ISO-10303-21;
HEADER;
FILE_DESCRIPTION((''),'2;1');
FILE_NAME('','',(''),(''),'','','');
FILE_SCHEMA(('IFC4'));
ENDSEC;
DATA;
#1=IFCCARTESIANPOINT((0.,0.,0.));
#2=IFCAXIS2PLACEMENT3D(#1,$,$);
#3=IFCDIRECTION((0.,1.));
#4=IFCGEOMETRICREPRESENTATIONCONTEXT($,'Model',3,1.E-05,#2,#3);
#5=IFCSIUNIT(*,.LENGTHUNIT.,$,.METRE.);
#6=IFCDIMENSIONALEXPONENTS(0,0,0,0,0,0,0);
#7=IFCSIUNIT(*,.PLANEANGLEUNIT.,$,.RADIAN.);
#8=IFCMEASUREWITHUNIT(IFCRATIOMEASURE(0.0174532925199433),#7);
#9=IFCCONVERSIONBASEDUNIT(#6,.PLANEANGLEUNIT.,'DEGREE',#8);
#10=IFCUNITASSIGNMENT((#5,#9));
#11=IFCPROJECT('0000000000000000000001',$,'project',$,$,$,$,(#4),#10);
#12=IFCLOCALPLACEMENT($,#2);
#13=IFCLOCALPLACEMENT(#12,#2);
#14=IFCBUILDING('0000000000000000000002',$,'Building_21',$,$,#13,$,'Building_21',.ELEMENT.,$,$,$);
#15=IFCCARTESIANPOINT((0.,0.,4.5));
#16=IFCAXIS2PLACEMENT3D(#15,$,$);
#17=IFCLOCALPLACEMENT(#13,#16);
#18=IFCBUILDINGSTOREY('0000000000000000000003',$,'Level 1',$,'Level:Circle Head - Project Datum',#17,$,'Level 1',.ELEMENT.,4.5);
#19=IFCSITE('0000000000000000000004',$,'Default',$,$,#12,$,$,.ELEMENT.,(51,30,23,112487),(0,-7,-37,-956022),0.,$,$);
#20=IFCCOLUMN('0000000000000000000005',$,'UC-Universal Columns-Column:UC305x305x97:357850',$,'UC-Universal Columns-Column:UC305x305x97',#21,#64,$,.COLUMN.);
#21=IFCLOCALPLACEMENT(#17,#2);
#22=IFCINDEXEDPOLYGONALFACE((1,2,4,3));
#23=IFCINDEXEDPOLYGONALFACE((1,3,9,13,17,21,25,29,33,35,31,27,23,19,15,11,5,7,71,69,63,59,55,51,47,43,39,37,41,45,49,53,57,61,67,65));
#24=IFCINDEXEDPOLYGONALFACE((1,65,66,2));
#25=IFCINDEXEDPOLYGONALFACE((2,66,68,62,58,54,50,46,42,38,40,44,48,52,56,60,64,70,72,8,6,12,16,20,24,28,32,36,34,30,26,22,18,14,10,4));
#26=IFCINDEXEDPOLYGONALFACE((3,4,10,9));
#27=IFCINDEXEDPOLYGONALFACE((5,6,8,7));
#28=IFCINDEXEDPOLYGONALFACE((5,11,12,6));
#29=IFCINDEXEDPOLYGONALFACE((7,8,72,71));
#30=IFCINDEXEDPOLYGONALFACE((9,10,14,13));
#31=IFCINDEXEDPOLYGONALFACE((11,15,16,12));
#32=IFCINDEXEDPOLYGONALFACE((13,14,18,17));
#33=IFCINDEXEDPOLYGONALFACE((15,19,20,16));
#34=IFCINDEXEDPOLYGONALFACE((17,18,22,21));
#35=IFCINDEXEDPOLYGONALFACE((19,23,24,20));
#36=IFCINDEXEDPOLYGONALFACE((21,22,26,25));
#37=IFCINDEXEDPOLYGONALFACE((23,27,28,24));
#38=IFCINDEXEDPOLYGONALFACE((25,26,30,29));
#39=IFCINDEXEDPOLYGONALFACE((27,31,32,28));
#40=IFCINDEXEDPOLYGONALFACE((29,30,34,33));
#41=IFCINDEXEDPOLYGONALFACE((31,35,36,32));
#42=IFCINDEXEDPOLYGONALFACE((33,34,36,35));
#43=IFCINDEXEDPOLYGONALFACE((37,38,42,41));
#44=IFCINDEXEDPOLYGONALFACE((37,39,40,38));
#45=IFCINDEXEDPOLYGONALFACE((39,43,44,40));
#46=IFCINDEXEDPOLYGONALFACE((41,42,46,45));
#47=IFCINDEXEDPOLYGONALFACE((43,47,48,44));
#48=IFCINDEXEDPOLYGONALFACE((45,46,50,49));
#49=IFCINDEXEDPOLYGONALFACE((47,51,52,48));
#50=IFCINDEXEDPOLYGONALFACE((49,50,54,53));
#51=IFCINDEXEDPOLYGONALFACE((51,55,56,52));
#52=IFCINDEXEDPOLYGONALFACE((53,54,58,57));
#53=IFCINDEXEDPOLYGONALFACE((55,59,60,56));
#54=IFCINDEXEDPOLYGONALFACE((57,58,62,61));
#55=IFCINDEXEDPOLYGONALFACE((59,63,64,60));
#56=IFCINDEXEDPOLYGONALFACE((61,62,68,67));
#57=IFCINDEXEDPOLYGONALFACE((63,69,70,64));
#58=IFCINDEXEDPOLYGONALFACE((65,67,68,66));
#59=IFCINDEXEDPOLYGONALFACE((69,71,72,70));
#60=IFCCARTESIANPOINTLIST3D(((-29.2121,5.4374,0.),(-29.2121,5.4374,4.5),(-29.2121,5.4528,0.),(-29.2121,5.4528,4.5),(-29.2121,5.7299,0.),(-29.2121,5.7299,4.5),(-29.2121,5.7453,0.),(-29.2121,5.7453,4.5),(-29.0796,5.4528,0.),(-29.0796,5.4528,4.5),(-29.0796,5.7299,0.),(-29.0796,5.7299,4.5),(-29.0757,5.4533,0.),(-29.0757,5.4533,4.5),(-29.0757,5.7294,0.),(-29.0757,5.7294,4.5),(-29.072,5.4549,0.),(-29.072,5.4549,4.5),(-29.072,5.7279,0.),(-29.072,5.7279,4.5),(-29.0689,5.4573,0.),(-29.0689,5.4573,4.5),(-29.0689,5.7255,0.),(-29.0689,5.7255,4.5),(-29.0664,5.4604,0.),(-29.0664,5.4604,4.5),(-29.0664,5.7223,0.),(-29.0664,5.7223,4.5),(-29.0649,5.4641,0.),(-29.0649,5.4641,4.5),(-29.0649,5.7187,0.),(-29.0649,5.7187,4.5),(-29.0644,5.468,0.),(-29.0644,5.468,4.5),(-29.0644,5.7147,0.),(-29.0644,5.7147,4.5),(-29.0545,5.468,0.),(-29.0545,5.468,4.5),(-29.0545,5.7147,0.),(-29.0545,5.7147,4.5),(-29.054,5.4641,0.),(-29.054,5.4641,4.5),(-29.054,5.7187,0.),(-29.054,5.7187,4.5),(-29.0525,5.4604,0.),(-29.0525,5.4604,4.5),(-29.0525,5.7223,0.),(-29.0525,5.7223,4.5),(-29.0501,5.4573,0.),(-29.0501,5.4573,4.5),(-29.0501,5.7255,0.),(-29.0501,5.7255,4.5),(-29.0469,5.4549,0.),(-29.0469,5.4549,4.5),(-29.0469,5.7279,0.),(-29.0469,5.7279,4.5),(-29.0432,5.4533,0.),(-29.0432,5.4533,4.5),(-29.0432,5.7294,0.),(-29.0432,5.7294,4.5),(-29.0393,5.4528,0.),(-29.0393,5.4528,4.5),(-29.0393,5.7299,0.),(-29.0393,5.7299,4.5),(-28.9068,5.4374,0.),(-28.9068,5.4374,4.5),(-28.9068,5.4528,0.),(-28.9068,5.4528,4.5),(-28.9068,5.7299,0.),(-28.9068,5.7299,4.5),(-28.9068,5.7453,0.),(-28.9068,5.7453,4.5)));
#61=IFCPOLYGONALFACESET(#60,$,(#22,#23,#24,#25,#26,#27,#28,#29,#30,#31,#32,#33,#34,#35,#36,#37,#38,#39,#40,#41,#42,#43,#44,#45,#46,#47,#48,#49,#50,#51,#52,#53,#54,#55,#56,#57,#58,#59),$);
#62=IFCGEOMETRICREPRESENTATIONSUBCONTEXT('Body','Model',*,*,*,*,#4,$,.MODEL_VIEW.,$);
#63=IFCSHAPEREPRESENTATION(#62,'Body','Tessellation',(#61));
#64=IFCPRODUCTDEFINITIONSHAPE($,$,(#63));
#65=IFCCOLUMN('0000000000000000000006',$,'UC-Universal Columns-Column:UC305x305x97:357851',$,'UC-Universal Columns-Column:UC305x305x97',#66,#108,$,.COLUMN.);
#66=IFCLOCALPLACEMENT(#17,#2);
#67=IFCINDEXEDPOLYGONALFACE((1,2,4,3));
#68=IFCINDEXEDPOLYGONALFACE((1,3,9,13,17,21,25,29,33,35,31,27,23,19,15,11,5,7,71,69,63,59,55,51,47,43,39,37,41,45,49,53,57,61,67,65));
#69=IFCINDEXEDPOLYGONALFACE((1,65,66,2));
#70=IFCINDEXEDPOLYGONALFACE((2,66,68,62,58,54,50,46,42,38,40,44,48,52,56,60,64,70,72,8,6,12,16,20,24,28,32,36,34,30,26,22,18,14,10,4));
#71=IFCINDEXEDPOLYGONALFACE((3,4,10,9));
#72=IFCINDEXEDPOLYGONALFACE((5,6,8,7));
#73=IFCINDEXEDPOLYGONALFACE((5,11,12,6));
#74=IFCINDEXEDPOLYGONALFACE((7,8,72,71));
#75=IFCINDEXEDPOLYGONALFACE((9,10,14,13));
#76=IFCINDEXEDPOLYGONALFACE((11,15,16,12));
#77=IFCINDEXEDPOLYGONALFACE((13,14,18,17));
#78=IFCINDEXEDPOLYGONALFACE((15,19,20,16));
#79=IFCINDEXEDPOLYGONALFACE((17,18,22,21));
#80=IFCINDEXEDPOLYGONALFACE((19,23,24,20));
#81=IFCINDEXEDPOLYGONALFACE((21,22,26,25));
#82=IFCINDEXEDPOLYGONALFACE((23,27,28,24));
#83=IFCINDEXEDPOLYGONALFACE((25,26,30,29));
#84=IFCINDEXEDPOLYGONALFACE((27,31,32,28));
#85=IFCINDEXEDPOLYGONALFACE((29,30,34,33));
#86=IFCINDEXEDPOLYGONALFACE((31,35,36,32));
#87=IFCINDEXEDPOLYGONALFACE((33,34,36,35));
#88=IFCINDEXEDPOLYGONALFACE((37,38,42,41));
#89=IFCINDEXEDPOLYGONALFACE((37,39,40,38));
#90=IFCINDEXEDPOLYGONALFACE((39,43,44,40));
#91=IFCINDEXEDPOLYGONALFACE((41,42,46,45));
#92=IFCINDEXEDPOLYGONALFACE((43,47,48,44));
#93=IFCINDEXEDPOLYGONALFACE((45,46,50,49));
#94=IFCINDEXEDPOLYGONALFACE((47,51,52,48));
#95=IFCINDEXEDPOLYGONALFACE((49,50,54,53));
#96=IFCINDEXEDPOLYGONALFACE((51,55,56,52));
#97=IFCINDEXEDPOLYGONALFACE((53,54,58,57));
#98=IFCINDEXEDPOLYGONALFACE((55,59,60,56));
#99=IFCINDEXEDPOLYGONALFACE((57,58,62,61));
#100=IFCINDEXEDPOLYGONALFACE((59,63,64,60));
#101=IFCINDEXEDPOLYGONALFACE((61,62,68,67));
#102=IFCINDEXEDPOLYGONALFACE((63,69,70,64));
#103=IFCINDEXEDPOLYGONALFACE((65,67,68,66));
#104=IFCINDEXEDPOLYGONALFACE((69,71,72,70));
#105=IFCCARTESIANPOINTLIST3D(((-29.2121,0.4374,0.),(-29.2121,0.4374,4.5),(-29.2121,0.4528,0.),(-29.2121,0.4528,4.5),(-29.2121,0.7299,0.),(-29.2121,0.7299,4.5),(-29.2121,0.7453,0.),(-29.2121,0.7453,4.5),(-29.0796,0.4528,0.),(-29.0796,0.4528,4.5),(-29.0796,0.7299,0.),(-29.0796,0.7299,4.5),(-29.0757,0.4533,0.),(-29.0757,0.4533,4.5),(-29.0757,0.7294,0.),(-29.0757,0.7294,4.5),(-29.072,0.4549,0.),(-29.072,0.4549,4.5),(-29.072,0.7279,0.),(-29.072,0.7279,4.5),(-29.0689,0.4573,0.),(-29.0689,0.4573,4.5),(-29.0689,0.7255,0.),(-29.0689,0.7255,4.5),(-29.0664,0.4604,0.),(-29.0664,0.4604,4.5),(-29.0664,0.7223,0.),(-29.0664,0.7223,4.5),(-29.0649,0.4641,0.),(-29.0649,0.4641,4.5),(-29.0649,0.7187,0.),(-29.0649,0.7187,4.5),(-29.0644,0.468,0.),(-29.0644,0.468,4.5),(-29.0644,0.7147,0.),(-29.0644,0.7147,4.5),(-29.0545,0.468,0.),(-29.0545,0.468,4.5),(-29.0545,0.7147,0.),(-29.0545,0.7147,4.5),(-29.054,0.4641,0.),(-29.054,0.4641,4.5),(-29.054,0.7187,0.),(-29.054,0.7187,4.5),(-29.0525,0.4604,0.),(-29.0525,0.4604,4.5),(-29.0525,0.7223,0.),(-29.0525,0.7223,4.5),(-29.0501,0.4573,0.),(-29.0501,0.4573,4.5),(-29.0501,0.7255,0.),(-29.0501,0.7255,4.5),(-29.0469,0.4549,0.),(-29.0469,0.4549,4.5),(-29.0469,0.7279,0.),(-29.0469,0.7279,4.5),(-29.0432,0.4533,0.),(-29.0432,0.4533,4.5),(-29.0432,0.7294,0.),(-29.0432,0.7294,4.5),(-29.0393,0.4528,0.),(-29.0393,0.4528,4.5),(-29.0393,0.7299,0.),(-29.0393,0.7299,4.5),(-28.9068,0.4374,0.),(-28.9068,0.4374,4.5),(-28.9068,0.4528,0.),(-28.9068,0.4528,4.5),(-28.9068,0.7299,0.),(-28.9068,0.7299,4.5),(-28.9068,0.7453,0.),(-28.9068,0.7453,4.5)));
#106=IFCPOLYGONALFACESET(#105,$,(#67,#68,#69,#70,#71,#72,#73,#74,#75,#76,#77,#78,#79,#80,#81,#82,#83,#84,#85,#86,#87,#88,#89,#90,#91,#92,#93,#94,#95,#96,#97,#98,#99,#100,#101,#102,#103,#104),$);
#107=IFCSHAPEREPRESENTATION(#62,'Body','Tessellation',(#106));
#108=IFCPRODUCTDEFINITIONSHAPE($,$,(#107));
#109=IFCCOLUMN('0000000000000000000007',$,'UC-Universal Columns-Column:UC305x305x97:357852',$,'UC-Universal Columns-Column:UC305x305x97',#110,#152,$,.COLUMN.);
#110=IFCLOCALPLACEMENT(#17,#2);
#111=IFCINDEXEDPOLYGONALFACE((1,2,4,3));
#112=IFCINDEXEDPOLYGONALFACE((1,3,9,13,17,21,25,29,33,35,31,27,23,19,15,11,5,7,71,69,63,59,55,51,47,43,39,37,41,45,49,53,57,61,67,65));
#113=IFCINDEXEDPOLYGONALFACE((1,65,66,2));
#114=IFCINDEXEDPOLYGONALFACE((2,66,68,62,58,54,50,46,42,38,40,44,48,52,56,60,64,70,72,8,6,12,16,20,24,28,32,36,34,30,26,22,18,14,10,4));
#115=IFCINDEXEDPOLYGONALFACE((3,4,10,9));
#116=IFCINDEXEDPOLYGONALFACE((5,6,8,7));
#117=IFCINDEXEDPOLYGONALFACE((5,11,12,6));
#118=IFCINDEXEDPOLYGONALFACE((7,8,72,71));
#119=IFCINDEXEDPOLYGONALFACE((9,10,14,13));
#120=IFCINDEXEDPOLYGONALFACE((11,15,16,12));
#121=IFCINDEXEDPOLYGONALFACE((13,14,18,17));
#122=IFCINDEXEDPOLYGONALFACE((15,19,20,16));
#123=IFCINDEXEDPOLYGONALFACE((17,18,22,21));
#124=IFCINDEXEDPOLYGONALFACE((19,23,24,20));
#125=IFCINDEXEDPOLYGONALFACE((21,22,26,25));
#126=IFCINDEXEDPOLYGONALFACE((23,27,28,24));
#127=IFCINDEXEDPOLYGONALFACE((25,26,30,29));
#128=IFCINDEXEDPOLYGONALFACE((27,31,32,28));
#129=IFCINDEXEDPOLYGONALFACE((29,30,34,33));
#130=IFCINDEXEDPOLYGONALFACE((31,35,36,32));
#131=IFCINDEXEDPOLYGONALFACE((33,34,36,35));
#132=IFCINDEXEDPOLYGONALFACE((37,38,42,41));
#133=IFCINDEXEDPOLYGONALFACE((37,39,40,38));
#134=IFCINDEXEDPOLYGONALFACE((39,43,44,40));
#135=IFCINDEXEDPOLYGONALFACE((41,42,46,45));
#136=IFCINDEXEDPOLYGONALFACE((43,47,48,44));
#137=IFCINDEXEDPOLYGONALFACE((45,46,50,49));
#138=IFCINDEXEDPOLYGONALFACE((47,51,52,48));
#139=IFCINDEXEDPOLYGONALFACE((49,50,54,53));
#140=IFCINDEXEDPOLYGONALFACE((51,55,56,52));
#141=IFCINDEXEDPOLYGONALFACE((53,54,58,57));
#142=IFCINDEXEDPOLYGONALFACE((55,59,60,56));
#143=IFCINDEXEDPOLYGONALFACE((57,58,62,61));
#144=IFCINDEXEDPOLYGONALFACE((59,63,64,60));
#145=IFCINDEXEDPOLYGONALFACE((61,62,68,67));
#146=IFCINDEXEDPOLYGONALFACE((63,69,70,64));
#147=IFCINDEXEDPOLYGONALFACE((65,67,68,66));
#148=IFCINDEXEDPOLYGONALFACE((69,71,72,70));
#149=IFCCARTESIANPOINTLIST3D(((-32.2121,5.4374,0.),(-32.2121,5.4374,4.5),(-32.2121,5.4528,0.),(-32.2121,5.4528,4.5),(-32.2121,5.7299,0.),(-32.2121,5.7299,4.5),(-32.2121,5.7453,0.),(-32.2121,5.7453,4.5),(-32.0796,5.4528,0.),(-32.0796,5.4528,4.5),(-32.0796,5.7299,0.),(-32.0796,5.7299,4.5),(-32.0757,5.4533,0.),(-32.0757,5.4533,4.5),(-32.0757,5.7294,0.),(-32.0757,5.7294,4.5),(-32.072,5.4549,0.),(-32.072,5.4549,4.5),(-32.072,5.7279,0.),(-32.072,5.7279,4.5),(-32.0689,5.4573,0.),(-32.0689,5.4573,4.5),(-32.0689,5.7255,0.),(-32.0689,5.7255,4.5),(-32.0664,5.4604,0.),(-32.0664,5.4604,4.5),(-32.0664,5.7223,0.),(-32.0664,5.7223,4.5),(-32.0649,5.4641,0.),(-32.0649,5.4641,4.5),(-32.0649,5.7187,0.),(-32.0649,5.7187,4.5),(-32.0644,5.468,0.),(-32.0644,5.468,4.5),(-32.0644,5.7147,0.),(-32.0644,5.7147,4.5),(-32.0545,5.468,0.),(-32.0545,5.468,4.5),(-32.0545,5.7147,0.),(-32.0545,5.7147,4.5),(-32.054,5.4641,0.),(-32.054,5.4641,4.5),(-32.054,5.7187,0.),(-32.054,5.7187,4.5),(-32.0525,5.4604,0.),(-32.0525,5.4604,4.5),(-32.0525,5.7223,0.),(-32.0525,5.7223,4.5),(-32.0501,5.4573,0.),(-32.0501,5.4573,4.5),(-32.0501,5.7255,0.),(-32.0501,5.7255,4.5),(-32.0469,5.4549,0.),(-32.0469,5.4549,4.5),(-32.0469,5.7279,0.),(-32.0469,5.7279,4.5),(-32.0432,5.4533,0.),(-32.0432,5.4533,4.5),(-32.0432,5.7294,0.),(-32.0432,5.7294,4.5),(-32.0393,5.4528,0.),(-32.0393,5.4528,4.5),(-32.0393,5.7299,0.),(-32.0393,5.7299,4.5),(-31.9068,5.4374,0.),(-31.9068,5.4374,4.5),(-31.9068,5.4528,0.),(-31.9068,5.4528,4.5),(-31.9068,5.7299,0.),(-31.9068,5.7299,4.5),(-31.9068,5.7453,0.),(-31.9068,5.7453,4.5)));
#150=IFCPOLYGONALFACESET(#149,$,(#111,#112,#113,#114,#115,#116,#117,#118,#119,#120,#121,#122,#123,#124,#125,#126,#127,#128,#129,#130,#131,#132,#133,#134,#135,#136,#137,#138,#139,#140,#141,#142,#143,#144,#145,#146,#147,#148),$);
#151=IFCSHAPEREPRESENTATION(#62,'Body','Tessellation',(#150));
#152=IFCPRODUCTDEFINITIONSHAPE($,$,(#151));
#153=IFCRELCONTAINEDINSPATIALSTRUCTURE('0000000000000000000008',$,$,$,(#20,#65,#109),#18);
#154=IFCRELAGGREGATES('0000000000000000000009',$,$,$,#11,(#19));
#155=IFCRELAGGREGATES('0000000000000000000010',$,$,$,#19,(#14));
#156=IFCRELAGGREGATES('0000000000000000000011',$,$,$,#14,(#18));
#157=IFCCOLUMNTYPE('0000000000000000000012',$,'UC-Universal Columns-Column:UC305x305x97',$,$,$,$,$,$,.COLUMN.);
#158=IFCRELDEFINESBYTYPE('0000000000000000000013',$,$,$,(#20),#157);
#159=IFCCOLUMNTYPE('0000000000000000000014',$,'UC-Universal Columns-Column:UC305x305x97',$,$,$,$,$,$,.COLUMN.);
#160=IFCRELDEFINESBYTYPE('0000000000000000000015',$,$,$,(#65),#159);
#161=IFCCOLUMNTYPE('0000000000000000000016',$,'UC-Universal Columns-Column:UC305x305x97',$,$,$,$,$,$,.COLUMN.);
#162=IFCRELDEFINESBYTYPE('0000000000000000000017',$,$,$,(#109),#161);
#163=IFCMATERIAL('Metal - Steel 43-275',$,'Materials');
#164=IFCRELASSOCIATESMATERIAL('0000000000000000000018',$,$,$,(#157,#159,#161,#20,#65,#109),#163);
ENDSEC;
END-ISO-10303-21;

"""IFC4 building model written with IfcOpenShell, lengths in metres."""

from ifc_helpers import new_model, entity, si_unit, converted_unit, direction, frame, frame_2d, origin, place, context, subcontext, project, spatial, polyline, circle_curve, parameter, trimmed, segment, composite_curve, i_section, outline, extrude, source, transform, mapped, material, material_profile, profile_set, profile_usage, type_object, type_shapes, element, save


model = new_model("IFC4")

# Units and contexts
model_context = context("Model", 3, precision=1e-05, world=origin(), true_north=direction((0.0, 1.0)))
body_context = subcontext(model_context, "Body", "Model", "MODEL_VIEW")
ifc_project = project(units=[si_unit("LENGTHUNIT", "METRE"), converted_unit("PLANEANGLEUNIT", "DEGREE", entity("IfcRatioMeasure", 0.0174532925199433), si_unit("PLANEANGLEUNIT", "RADIAN"), dimensions=[0, 0, 0, 0, 0, 0, 0])], contexts=[model_context])

# Site, building, storey
site_placement = place(None, origin())
site = spatial("IfcSite", under=ifc_project, at=site_placement, Name="Default", CompositionType="ELEMENT", RefLatitude=(51, 30, 23, 112487), RefLongitude=(0, -7, -37, -956022), RefElevation=0.0)
building_placement = place(site_placement, origin())
building = spatial("IfcBuilding", under=site, at=building_placement, Name="Building_21", LongName="Building_21", CompositionType="ELEMENT")
storey_placement = place(building_placement, frame((0.0, 0.0, 4.5)))
storey = spatial("IfcBuildingStorey", under=building, at=storey_placement, Name="Level 1", ObjectType="Level:Circle Head - Project Datum", LongName="Level 1", CompositionType="ELEMENT", Elevation=4.5)

# Columns
ifc_material_1 = material(Name="Metal - Steel 43-275", Category="Materials")
ifc_material_profile_1 = material_profile(ifc_material_1, outline(composite_curve([segment(polyline([(-0.1527, 0.154, 0.0), (0.1527, 0.154, 0.0)]), True, "CONTINUOUS"), segment(polyline([(0.1527, 0.154, 0.0), (0.1527, 0.1386, 0.0)]), True, "CONTINUOUS"), segment(polyline([(0.1527, 0.1386, 0.0), (0.0201, 0.1386, 0.0)]), True, "CONTINUOUS"), segment(trimmed(circle_curve(frame((0.0201, 0.1234, 0.0)), 0.0152), [parameter(90.0)], [parameter(180.0)], True, "PARAMETER"), True, "CONTINUOUS"), segment(polyline([(0.0049, 0.1234, 0.0), (0.0049, -0.1234, 0.0)]), True, "CONTINUOUS"), segment(trimmed(circle_curve(frame((0.0201, -0.1234, 0.0)), 0.0152), [parameter(180.0)], [parameter(270.0)], True, "PARAMETER"), True, "CONTINUOUS"), segment(polyline([(0.0201, -0.1386, 0.0), (0.1527, -0.1386, 0.0)]), True, "CONTINUOUS"), segment(polyline([(0.1527, -0.1386, 0.0), (0.1527, -0.154, 0.0)]), True, "CONTINUOUS"), segment(polyline([(0.1527, -0.154, 0.0), (-0.1527, -0.154, 0.0)]), True, "CONTINUOUS"), segment(polyline([(-0.1527, -0.154, 0.0), (-0.1527, -0.1386, 0.0)]), True, "CONTINUOUS"), segment(polyline([(-0.1527, -0.1386, 0.0), (-0.0201, -0.1386, 0.0)]), True, "CONTINUOUS"), segment(trimmed(circle_curve(frame((-0.0201, -0.1234, 0.0)), 0.0152), [parameter(270.0)], [parameter(0.0)], True, "PARAMETER"), True, "CONTINUOUS"), segment(polyline([(-0.0049, -0.1234, 0.0), (-0.005, 0.1234, 0.0)]), True, "CONTINUOUS"), segment(trimmed(circle_curve(frame((-0.0201, 0.1234, 0.0)), 0.0152), [parameter(0.0)], [parameter(90.0)], True, "PARAMETER"), True, "CONTINUOUS"), segment(polyline([(-0.0201, 0.1386, 0.0), (-0.1527, 0.1386, 0.0)]), True, "CONTINUOUS"), segment(polyline([(-0.1527, 0.1386, 0.0), (-0.1527, 0.154, 0.0)]), True, "CONTINUOUS")], self_intersect=False), kind="CURVE"), Name="UC305x305x97")
ifc_material_profile_2 = material_profile(ifc_material_1, outline(composite_curve([segment(polyline([(0.1527, 0.154, 0.0), (0.1527, 0.1386, 0.0)]), True, "CONTINUOUS"), segment(polyline([(0.1527, 0.1386, 0.0), (0.0049, 0.1386, 0.0)]), True, "CONTINUOUS"), segment(polyline([(0.0049, 0.1386, 0.0), (0.0049, -0.1386, 0.0)]), True, "CONTINUOUS"), segment(polyline([(0.0049, -0.1386, 0.0), (0.1527, -0.1386, 0.0)]), True, "CONTINUOUS"), segment(polyline([(0.1527, -0.1386, 0.0), (0.1527, -0.154, 0.0)]), True, "CONTINUOUS"), segment(polyline([(0.1527, -0.154, 0.0), (-0.1527, -0.154, 0.0)]), True, "CONTINUOUS"), segment(polyline([(-0.1527, -0.154, 0.0), (-0.1527, -0.1386, 0.0)]), True, "CONTINUOUS"), segment(polyline([(-0.1527, -0.1386, 0.0), (-0.005, -0.1386, 0.0)]), True, "CONTINUOUS"), segment(polyline([(-0.005, -0.1386, 0.0), (-0.005, 0.1386, 0.0)]), True, "CONTINUOUS"), segment(polyline([(-0.005, 0.1386, 0.0), (-0.1527, 0.1386, 0.0)]), True, "CONTINUOUS"), segment(polyline([(-0.1527, 0.1386, 0.0), (-0.1527, 0.154, 0.0)]), True, "CONTINUOUS"), segment(polyline([(-0.1527, 0.154, 0.0), (0.1527, 0.154, 0.0)]), True, "CONTINUOUS")], self_intersect=False), kind="CURVE"), Name="UC305x305x97")
ifc_profile_set_1 = profile_set([ifc_material_profile_1, ifc_material_profile_2], Name="UC305x305x97")
ifc_profile_usage_1 = profile_usage(ifc_profile_set_1)
column_type_1 = type_object("IfcColumnType", Name="UC-Universal Columns-Column:UC305x305x97", PredefinedType="COLUMN", material=ifc_profile_set_1)
shared_shape_1 = source(origin(), body_context, "Body", "SweptSolid", [
    extrude(i_section(OverallWidth=0.3053, OverallDepth=0.3079, WebThickness=0.0099, FlangeThickness=0.0154, FilletRadius=0.0152, at=frame_2d((0.0, 0.0), x_axis=(0.0, 1.0))), frame((-29.0595, 5.5914, 4.5), z_axis=(0.0, 0.0, 1.0), x_axis=(0.0, -1.0, 0.0)), (0.0, 0.0, 1.0), 4.5),
])
type_shapes(column_type_1, [shared_shape_1])
column_1_placement = place(storey_placement, frame((0.0, 0.0, -4.5)))
element("IfcColumn", 1, at=column_1_placement, inside=storey, type_object=column_type_1, material=ifc_profile_usage_1, Name="UC-Universal Columns-Column:UC305x305x97:357850", ObjectType="UC-Universal Columns-Column:UC305x305x97", PredefinedType="COLUMN", context=body_context, shape_type="MappedRepresentation", body=[
    mapped(shared_shape_1, transform((0.0, 0.0, 0.0), scale=1.0)),
])
ifc_profile_usage_2 = profile_usage(ifc_profile_set_1)
column_type_2 = type_object("IfcColumnType", Name="UC-Universal Columns-Column:UC305x305x97", PredefinedType="COLUMN", material=ifc_profile_set_1)
shared_shape_2 = source(origin(), body_context, "Body", "SweptSolid", [
    extrude(i_section(OverallWidth=0.3053, OverallDepth=0.3079, WebThickness=0.0099, FlangeThickness=0.0154, FilletRadius=0.0152, at=frame_2d((0.0, 0.0), x_axis=(0.0, 1.0))), frame((-29.0595, 0.5914, 4.5), z_axis=(0.0, 0.0, 1.0), x_axis=(0.0, -1.0, 0.0)), (0.0, 0.0, 1.0), 4.5),
])
type_shapes(column_type_2, [shared_shape_2])
column_2_placement = place(storey_placement, frame((0.0, 0.0, -4.5)))
element("IfcColumn", 2, at=column_2_placement, inside=storey, type_object=column_type_2, material=ifc_profile_usage_2, Name="UC-Universal Columns-Column:UC305x305x97:357851", ObjectType="UC-Universal Columns-Column:UC305x305x97", PredefinedType="COLUMN", context=body_context, shape_type="MappedRepresentation", body=[
    mapped(shared_shape_2, transform((0.0, 0.0, 0.0), scale=1.0)),
])
ifc_profile_usage_3 = profile_usage(ifc_profile_set_1)
column_type_3 = type_object("IfcColumnType", Name="UC-Universal Columns-Column:UC305x305x97", PredefinedType="COLUMN", material=ifc_profile_set_1)
shared_shape_3 = source(origin(), body_context, "Body", "SweptSolid", [
    extrude(i_section(OverallWidth=0.3053, OverallDepth=0.3079, WebThickness=0.0099, FlangeThickness=0.0154, FilletRadius=0.0152, at=frame_2d((0.0, 0.0), x_axis=(0.0, 1.0))), frame((-32.0595, 5.5914, 4.5), z_axis=(0.0, 0.0, 1.0), x_axis=(0.0, -1.0, 0.0)), (0.0, 0.0, 1.0), 4.5),
])
type_shapes(column_type_3, [shared_shape_3])
column_3_placement = place(storey_placement, frame((0.0, 0.0, -4.5)))
element("IfcColumn", 3, at=column_3_placement, inside=storey, type_object=column_type_3, material=ifc_profile_usage_3, Name="UC-Universal Columns-Column:UC305x305x97:357852", ObjectType="UC-Universal Columns-Column:UC305x305x97", PredefinedType="COLUMN", context=body_context, shape_type="MappedRepresentation", body=[
    mapped(shared_shape_3, transform((0.0, 0.0, 0.0), scale=1.0)),
])

save(model, "model.ifc")
